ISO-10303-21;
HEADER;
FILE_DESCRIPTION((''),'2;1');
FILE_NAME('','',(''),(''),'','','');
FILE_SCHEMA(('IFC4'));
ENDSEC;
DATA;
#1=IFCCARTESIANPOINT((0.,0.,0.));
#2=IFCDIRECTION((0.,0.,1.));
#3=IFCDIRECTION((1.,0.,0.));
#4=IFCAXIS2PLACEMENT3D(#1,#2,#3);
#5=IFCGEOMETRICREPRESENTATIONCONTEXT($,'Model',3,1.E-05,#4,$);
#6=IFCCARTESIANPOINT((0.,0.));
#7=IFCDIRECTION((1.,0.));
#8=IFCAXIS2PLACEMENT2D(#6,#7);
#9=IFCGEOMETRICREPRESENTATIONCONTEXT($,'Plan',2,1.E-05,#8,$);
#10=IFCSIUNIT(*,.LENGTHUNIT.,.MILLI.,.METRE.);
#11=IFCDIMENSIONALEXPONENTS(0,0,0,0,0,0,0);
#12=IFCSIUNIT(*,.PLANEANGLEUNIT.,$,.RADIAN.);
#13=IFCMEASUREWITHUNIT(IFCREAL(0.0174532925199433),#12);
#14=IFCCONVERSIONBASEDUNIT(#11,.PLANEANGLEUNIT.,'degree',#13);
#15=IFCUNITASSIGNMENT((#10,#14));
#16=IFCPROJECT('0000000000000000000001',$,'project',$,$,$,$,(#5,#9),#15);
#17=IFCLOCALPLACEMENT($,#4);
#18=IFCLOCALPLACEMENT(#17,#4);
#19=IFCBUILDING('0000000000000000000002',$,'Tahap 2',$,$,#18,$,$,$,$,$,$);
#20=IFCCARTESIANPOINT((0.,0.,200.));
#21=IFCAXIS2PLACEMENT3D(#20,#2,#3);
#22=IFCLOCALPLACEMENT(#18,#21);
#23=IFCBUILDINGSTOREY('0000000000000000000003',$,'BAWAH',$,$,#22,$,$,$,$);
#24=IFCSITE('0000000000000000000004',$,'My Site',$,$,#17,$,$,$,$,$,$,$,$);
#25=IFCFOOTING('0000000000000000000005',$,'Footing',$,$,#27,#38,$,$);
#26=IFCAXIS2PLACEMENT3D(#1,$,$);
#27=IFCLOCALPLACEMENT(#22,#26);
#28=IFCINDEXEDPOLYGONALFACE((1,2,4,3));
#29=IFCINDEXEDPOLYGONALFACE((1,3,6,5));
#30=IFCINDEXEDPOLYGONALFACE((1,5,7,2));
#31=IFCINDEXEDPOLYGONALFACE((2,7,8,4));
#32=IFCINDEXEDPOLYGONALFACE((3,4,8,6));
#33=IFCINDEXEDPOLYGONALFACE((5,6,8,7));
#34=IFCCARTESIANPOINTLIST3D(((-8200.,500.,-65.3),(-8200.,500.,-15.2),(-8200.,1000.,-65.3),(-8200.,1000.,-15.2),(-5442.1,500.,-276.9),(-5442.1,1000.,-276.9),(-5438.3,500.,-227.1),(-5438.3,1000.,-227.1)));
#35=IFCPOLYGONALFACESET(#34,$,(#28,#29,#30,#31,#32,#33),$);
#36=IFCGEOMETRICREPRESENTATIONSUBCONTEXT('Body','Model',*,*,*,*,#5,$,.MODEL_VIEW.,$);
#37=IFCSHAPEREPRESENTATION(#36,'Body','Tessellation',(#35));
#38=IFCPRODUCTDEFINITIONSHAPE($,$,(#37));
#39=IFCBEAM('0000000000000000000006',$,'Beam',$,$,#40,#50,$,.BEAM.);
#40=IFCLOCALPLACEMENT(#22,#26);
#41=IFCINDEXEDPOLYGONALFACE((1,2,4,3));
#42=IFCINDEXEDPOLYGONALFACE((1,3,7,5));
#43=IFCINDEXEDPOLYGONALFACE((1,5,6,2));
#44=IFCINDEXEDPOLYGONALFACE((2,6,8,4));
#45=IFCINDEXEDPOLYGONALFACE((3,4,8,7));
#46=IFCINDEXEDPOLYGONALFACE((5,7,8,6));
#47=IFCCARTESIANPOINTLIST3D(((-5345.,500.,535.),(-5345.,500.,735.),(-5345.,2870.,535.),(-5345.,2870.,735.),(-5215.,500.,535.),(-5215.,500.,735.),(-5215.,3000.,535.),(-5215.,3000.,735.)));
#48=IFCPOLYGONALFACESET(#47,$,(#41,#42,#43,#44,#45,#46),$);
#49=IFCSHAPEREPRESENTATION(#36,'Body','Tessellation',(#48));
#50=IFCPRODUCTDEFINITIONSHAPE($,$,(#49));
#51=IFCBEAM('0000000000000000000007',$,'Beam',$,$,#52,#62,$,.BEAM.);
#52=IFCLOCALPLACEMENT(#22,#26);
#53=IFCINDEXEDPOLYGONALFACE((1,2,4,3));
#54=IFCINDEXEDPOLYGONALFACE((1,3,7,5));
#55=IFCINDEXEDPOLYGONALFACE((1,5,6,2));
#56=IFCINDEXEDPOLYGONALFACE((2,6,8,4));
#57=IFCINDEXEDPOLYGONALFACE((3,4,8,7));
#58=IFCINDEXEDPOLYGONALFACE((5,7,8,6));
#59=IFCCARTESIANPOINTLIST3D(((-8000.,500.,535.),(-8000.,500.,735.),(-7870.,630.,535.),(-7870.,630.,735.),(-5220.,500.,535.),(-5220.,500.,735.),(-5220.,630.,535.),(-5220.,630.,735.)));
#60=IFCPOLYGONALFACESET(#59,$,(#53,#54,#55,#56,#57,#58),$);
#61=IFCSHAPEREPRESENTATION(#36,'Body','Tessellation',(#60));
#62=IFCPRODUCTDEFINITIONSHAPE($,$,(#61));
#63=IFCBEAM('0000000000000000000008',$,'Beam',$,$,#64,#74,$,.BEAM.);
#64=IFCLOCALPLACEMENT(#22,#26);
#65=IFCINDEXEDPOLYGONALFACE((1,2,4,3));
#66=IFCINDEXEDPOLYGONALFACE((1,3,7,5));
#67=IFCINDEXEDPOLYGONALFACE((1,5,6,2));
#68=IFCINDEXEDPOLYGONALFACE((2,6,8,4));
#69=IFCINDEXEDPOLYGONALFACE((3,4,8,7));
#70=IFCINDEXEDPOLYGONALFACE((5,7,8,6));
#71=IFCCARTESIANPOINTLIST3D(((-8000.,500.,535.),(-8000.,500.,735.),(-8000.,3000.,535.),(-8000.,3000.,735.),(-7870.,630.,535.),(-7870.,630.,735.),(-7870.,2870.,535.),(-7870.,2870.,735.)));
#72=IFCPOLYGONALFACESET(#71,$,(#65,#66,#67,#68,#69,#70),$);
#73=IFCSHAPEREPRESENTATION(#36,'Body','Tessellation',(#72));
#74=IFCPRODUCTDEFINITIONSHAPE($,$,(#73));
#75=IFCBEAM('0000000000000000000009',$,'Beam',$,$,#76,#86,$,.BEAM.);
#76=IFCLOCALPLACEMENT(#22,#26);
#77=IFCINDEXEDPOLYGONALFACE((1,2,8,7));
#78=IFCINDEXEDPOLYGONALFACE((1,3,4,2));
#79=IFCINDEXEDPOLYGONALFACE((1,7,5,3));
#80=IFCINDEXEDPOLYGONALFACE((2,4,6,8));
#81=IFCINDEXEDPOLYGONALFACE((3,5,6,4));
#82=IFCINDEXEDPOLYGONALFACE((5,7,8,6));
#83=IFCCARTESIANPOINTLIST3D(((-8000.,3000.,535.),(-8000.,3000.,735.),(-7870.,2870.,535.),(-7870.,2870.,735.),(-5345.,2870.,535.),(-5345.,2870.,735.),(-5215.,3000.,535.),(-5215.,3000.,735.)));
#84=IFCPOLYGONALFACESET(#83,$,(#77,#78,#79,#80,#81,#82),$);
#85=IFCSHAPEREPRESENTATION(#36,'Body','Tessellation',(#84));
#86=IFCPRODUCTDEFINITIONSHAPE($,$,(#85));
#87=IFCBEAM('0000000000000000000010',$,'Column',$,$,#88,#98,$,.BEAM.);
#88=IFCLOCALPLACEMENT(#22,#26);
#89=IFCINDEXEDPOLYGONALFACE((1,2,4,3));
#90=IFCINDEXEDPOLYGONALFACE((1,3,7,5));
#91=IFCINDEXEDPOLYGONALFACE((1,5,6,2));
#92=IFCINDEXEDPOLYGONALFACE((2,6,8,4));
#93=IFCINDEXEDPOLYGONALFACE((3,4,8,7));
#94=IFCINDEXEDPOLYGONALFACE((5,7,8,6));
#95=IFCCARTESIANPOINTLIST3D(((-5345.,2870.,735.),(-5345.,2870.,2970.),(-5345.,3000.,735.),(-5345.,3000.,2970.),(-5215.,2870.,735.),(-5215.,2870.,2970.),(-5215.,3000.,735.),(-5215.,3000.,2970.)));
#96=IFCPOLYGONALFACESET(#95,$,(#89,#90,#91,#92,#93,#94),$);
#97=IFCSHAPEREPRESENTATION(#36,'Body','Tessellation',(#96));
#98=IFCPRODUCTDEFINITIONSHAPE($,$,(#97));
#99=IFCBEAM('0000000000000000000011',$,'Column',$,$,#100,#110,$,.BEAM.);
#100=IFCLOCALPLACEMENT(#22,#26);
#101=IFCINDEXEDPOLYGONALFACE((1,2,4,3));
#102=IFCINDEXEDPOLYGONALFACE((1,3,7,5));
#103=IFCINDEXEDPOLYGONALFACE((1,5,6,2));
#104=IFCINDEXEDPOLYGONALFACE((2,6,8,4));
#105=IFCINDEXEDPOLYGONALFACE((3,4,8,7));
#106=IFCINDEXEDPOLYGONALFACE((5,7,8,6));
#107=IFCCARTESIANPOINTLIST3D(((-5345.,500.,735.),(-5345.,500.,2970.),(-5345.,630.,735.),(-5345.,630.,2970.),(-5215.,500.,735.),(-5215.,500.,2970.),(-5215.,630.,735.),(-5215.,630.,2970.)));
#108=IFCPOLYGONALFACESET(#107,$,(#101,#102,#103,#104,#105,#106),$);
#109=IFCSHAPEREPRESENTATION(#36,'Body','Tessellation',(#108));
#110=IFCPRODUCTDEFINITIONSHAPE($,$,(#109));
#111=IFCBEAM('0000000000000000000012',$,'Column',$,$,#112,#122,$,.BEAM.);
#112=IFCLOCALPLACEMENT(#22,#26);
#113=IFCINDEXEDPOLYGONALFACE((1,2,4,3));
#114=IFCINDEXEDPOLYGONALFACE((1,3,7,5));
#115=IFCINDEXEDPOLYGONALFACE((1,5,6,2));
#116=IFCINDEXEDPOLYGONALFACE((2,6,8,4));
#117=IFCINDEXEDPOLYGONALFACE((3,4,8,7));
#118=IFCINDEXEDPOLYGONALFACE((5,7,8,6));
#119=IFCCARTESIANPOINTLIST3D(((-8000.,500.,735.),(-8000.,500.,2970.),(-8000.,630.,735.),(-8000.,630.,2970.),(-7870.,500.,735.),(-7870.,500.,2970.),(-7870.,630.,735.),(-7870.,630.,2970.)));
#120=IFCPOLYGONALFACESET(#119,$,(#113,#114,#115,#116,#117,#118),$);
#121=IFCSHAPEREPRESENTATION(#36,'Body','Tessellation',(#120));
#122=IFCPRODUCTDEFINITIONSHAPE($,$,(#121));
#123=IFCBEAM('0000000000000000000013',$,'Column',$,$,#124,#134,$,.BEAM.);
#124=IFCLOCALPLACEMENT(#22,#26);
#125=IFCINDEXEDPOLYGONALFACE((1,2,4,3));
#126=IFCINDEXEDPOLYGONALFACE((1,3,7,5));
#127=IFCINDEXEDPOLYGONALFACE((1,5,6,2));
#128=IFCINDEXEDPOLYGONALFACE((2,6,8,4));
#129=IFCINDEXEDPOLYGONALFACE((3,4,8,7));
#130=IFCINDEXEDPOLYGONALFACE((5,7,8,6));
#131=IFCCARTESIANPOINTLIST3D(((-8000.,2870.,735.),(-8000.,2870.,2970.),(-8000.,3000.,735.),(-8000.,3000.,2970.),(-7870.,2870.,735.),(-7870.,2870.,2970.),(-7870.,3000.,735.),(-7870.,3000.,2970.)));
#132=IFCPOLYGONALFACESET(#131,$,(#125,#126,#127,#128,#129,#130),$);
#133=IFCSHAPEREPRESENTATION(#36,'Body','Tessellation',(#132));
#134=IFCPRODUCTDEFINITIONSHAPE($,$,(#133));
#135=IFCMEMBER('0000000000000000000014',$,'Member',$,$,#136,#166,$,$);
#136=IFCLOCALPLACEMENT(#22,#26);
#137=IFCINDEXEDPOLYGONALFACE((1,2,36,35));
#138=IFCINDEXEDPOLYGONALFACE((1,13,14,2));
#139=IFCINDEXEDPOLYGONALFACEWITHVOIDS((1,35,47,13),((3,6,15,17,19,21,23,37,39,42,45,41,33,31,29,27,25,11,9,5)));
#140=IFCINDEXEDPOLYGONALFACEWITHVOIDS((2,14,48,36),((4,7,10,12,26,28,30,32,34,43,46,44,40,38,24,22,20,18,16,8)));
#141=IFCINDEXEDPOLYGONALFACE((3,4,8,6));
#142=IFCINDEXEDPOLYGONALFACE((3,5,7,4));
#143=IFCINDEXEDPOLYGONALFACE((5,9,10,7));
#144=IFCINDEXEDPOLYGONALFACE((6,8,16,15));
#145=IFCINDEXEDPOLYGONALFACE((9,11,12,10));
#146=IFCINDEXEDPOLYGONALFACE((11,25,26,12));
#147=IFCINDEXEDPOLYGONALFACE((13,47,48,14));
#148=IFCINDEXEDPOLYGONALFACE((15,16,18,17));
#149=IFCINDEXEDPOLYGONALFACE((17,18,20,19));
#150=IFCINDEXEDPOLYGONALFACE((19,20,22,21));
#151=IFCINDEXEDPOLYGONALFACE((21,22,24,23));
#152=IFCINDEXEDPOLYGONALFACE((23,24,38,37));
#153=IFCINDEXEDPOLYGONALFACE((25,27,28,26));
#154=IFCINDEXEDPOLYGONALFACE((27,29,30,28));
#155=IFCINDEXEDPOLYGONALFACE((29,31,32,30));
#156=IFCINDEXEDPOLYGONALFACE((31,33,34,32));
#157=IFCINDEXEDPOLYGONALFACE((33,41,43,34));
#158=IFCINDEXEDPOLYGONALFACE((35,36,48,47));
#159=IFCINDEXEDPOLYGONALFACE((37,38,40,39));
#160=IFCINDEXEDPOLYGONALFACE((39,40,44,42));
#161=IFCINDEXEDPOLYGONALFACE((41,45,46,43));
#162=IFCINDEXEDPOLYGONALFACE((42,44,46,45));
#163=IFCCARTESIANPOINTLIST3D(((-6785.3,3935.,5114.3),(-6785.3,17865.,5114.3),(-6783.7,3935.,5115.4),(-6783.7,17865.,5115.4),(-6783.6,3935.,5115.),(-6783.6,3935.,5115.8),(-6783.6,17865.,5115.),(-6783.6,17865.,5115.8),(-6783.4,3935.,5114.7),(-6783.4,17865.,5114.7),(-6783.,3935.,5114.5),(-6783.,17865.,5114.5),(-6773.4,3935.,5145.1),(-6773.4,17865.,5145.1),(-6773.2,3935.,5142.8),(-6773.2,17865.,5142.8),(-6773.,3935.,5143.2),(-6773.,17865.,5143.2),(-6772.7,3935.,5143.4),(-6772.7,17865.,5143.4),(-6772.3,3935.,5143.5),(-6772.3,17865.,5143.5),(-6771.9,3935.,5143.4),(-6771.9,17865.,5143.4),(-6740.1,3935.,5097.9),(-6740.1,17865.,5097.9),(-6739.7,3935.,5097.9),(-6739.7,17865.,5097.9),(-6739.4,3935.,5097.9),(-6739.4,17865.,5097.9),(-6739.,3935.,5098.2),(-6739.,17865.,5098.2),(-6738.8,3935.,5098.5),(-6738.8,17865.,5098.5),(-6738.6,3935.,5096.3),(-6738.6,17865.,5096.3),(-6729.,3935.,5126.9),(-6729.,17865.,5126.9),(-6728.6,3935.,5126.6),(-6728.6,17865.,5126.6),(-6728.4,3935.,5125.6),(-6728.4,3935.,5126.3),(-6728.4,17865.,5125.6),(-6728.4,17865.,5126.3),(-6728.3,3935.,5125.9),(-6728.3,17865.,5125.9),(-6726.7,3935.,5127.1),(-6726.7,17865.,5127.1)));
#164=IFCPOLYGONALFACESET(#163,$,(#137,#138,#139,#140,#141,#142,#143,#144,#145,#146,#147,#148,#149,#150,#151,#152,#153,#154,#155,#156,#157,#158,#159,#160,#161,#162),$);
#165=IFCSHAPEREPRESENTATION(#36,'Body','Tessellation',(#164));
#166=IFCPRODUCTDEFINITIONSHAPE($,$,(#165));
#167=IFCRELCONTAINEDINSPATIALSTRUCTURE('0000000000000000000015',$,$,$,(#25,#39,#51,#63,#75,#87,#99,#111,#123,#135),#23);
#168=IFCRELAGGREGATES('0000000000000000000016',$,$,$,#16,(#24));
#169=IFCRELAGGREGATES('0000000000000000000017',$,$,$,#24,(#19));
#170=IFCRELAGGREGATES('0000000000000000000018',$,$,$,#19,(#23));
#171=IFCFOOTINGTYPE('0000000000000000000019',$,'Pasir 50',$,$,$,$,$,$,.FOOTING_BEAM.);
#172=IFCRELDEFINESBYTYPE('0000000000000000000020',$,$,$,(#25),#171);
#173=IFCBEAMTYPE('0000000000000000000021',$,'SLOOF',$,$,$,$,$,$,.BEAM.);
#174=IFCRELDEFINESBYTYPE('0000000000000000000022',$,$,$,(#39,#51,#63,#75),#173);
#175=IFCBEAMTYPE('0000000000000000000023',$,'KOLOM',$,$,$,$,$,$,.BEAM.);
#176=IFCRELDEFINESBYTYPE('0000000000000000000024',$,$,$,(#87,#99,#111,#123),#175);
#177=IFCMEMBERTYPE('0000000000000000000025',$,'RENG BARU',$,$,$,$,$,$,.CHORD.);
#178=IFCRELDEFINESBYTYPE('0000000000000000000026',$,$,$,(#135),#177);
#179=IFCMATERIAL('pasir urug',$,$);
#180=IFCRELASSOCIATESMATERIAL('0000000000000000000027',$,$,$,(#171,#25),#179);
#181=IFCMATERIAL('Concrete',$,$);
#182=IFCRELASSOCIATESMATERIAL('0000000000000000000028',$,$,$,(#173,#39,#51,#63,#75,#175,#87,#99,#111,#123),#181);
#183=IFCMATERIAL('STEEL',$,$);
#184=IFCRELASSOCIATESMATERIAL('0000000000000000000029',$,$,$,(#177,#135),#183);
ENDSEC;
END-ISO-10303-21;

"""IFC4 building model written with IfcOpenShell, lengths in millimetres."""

from ifc_helpers import new_model, entity, si_unit, converted_unit, frame, origin_with_axes, origin_2d_with_axis, place, context, subcontext, project, spatial, indexed_curve, rectangle, hollow_rectangle, outline, extrude, clip, halfspace, material, material_profile, profile_set, profile_usage, type_object, element, save


model = new_model("IFC4")

# Units and contexts
model_context = context("Model", 3, precision=1e-05, world=origin_with_axes())
plan_context = context("Plan", 2, precision=1e-05, world=origin_2d_with_axis())
body_context = subcontext(model_context, "Body", "Model", "MODEL_VIEW")
ifc_project = project(units=[si_unit("LENGTHUNIT", "METRE", prefix="MILLI"), converted_unit("PLANEANGLEUNIT", "degree", entity("IfcReal", 0.0174532925199433), si_unit("PLANEANGLEUNIT", "RADIAN"), dimensions=[0, 0, 0, 0, 0, 0, 0])], contexts=[model_context, plan_context])

# Site, building, storey
site_placement = place(None, origin_with_axes())
site = spatial("IfcSite", under=ifc_project, at=site_placement, Name="My Site")
building_placement = place(site_placement, origin_with_axes())
building = spatial("IfcBuilding", under=site, at=building_placement, Name="Tahap 2")
storey_placement = place(building_placement, frame((0.0, 0.0, 200.0), z_axis=(0.0, 0.0, 1.0), x_axis=(1.0, 0.0, 0.0)))
storey = spatial("IfcBuildingStorey", under=building, at=storey_placement, Name="BAWAH")

# Footing
ifc_material_1 = material(Name="pasir urug")
ifc_material_profile_1 = material_profile(ifc_material_1, rectangle(XDim=500.0, YDim=50.0, kind="CURVE"))
ifc_profile_set_1 = profile_set([ifc_material_profile_1])
ifc_profile_usage_1 = profile_usage(ifc_profile_set_1)
footing_type_1 = type_object("IfcFootingType", Name="Pasir 50", PredefinedType="FOOTING_BEAM", material=ifc_profile_set_1)
footing_1_placement = place(storey_placement, frame((-8698.5, 750.0, -2.0), z_axis=(0.99707, 0.0, -0.076496), x_axis=(0.0, 1.0, 0.0)))
element("IfcFooting", 1, at=footing_1_placement, inside=storey, type_object=footing_type_1, material=ifc_profile_usage_1, Name="Footing", context=body_context, shape_type="Clipping", body=[
    clip(extrude(rectangle(XDim=500.0, YDim=50.0, kind="CURVE"), origin_with_axes(), (0.0, 0.0, 1.0), 3267.9), halfspace(frame((2475.0, 25.2, 498.1), z_axis=(0.0, -0.076495, -0.99707), x_axis=(-1.0, -0.000005, 0.0)), False)),
])

# Beams
ifc_material_2 = material(Name="Concrete")
ifc_material_profile_2 = material_profile(ifc_material_2, outline(indexed_curve([(-65.0, 100.0), (65.0, 100.0), (65.0, -100.0), (-65.0, -100.0), (-65.0, 100.0)])))
ifc_profile_set_2 = profile_set([ifc_material_profile_2])
ifc_profile_usage_2 = profile_usage(ifc_profile_set_2, cardinal=5)
beam_type_1 = type_object("IfcBeamType", Name="SLOOF", PredefinedType="BEAM", material=ifc_profile_set_2)
beam_1_placement = place(storey_placement, frame((-5280.0, 500.0, 635.0), z_axis=(0.000001, 1.0, 0.0), x_axis=(-1.0, 0.000001, 0.0)))
element("IfcBeam", 2, at=beam_1_placement, inside=storey, type_object=beam_type_1, material=ifc_profile_usage_2, Name="Beam", PredefinedType="BEAM", context=body_context, shape_type="Clipping", body=[
    clip(extrude(outline(indexed_curve([(-65.0, 100.0), (65.0, 100.0), (65.0, -100.0), (-65.0, -100.0), (-65.0, 100.0)])), origin_with_axes(), (0.0, 0.0, 1.0), 2500.0), halfspace(frame((-65.0, -835.0, 2500.0), z_axis=(0.707107, 0.0, 0.707106), x_axis=(-0.000001, -1.0, 0.0)), False)),
])
ifc_profile_usage_3 = profile_usage(ifc_profile_set_2, cardinal=1)
beam_2_placement = place(storey_placement, frame((-5220.0, 500.0, 535.0), z_axis=(-1.0, 0.0, 0.0), x_axis=(0.0, -1.0, 0.0)))
element("IfcBeam", 3, at=beam_2_placement, inside=storey, type_object=beam_type_1, material=ifc_profile_usage_3, Name="Beam", PredefinedType="BEAM", context=body_context, shape_type="Clipping", body=[
    clip(extrude(outline(indexed_curve([(-65.0, 100.0), (65.0, 100.0), (65.0, -100.0), (-65.0, -100.0), (-65.0, 100.0)])), frame((-65.0, 100.0, 0.0), z_axis=(0.0, 0.0, 1.0), x_axis=(1.0, 0.0, 0.0)), (0.0, 0.0, 1.0), 2780.0), halfspace(frame((0.0, -735.0, 2780.0), z_axis=(-0.707107, 0.0, 0.707106), x_axis=(0.0, 1.0, 0.0)), False)),
])
ifc_profile_usage_4 = profile_usage(ifc_profile_set_2, cardinal=1)
beam_3_placement = place(storey_placement, frame((-8000.0, 500.0, 535.0), z_axis=(0.0, 1.0, 0.0), x_axis=(-1.0, 0.0, 0.0)))
element("IfcBeam", 4, at=beam_3_placement, inside=storey, type_object=beam_type_1, material=ifc_profile_usage_4, Name="Beam", PredefinedType="BEAM", context=body_context, shape_type="Clipping", body=[
    clip(clip(extrude(outline(indexed_curve([(-65.0, 100.0), (65.0, 100.0), (65.0, -100.0), (-65.0, -100.0), (-65.0, 100.0)])), frame((-65.0, 100.0, 0.0), z_axis=(0.0, 0.0, 1.0), x_axis=(1.0, 0.0, 0.0)), (0.0, 0.0, 1.0), 2500.0), halfspace(frame((0.0, -735.0, 2500.0), z_axis=(-0.707107, 0.0, 0.707107), x_axis=(0.0, 1.0, 0.0)), False)), halfspace(frame((0.0, -735.0, 0.0), z_axis=(-0.707106, 0.0, -0.707107), x_axis=(-0.000001, 1.0, 0.0)), False)),
])
ifc_profile_usage_5 = profile_usage(ifc_profile_set_2, cardinal=1)
beam_4_placement = place(storey_placement, frame((-8000.0, 3000.0, 535.0), z_axis=(1.0, -0.000001, 0.000001), x_axis=(0.000001, 1.0, 0.0)))
element("IfcBeam", 5, at=beam_4_placement, inside=storey, type_object=beam_type_1, material=ifc_profile_usage_5, Name="Beam", PredefinedType="BEAM", context=body_context, shape_type="Clipping", body=[
    clip(clip(extrude(outline(indexed_curve([(-65.0, 100.0), (65.0, 100.0), (65.0, -100.0), (-65.0, -100.0), (-65.0, 100.0)])), frame((-65.0, 100.0, 0.0), z_axis=(0.0, 0.0, 1.0), x_axis=(1.0, 0.0, 0.0)), (0.0, 0.0, 1.0), 2785.0), halfspace(frame((0.0, -735.0, 2785.0), z_axis=(-0.707106, -0.000001, 0.707107), x_axis=(-0.000001, 1.0, 0.0)), False)), halfspace(frame((0.0, -735.0, 0.0), z_axis=(-0.707107, 0.000001, -0.707106), x_axis=(0.000001, 1.0, 0.0)), False)),
])
ifc_material_profile_3 = material_profile(ifc_material_2, rectangle(XDim=130.0, YDim=130.0, kind="CURVE"))
ifc_profile_set_3 = profile_set([ifc_material_profile_3])
ifc_profile_usage_6 = profile_usage(ifc_profile_set_3, cardinal=5)
beam_type_2 = type_object("IfcBeamType", Name="KOLOM", PredefinedType="BEAM", material=ifc_profile_set_3)
beam_5_placement = place(storey_placement, frame((-5280.0, 2935.0, 735.0), z_axis=(0.0, 0.0, 1.0), x_axis=(1.0, 0.0, 0.0)))
element("IfcBeam", 6, at=beam_5_placement, inside=storey, type_object=beam_type_2, material=ifc_profile_usage_6, Name="Column", PredefinedType="BEAM", context=body_context, shape_type="SweptSolid", body=[
    extrude(rectangle(XDim=130.0, YDim=130.0, kind="CURVE"), origin_with_axes(), (0.0, 0.0, 1.0), 2235.0),
])
ifc_profile_usage_7 = profile_usage(ifc_profile_set_3, cardinal=5)
beam_6_placement = place(storey_placement, frame((-5280.0, 565.0, 735.0), z_axis=(0.0, 0.0, 1.0), x_axis=(1.0, 0.0, 0.0)))
element("IfcBeam", 7, at=beam_6_placement, inside=storey, type_object=beam_type_2, material=ifc_profile_usage_7, Name="Column", PredefinedType="BEAM", context=body_context, shape_type="SweptSolid", body=[
    extrude(rectangle(XDim=130.0, YDim=130.0, kind="CURVE"), origin_with_axes(), (0.0, 0.0, 1.0), 2235.0),
])
ifc_profile_usage_8 = profile_usage(ifc_profile_set_3, cardinal=5)
beam_7_placement = place(storey_placement, frame((-7935.0, 565.0, 735.0), z_axis=(0.0, 0.0, 1.0), x_axis=(1.0, 0.0, 0.0)))
element("IfcBeam", 8, at=beam_7_placement, inside=storey, type_object=beam_type_2, material=ifc_profile_usage_8, Name="Column", PredefinedType="BEAM", context=body_context, shape_type="SweptSolid", body=[
    extrude(rectangle(XDim=130.0, YDim=130.0, kind="CURVE"), origin_with_axes(), (0.0, 0.0, 1.0), 2235.0),
])
ifc_profile_usage_9 = profile_usage(ifc_profile_set_3, cardinal=5)
beam_8_placement = place(storey_placement, frame((-7935.0, 2935.0, 735.0), z_axis=(0.0, 0.0, 1.0), x_axis=(1.0, 0.0, 0.0)))
element("IfcBeam", 9, at=beam_8_placement, inside=storey, type_object=beam_type_2, material=ifc_profile_usage_9, Name="Column", PredefinedType="BEAM", context=body_context, shape_type="SweptSolid", body=[
    extrude(rectangle(XDim=130.0, YDim=130.0, kind="CURVE"), origin_with_axes(), (0.0, 0.0, 1.0), 2235.0),
])

# Member
ifc_material_3 = material(Name="STEEL")
ifc_material_profile_4 = material_profile(ifc_material_3, hollow_rectangle(XDim=50.0, YDim=33.0, WallThickness=1.0, InnerFilletRadius=1.0, OuterFilletRadius=0.0, kind="CURVE"))
ifc_profile_set_4 = profile_set([ifc_material_profile_4])
ifc_profile_usage_10 = profile_usage(ifc_profile_set_4, cardinal=3)
member_type_1 = type_object("IfcMemberType", Name="RENG BARU", PredefinedType="CHORD", material=ifc_profile_set_4)
member_1_placement = place(storey_placement, frame((-6738.6, 3935.0, 5096.3), z_axis=(0.0, 1.0, 0.0), x_axis=(-0.932954, 0.0, 0.359997)))
element("IfcMember", 10, at=member_1_placement, inside=storey, type_object=member_type_1, material=ifc_profile_usage_10, Name="Member", context=body_context, shape_type="SweptSolid", body=[
    extrude(hollow_rectangle(XDim=50.0, YDim=33.0, WallThickness=1.0, InnerFilletRadius=1.0, OuterFilletRadius=0.0, kind="CURVE"), frame((25.0, 16.5, 0.0), z_axis=(0.0, 0.0, 1.0), x_axis=(1.0, 0.0, 0.0)), (0.0, 0.0, 1.0), 13930.0),
])

save(model, "model.ifc")
